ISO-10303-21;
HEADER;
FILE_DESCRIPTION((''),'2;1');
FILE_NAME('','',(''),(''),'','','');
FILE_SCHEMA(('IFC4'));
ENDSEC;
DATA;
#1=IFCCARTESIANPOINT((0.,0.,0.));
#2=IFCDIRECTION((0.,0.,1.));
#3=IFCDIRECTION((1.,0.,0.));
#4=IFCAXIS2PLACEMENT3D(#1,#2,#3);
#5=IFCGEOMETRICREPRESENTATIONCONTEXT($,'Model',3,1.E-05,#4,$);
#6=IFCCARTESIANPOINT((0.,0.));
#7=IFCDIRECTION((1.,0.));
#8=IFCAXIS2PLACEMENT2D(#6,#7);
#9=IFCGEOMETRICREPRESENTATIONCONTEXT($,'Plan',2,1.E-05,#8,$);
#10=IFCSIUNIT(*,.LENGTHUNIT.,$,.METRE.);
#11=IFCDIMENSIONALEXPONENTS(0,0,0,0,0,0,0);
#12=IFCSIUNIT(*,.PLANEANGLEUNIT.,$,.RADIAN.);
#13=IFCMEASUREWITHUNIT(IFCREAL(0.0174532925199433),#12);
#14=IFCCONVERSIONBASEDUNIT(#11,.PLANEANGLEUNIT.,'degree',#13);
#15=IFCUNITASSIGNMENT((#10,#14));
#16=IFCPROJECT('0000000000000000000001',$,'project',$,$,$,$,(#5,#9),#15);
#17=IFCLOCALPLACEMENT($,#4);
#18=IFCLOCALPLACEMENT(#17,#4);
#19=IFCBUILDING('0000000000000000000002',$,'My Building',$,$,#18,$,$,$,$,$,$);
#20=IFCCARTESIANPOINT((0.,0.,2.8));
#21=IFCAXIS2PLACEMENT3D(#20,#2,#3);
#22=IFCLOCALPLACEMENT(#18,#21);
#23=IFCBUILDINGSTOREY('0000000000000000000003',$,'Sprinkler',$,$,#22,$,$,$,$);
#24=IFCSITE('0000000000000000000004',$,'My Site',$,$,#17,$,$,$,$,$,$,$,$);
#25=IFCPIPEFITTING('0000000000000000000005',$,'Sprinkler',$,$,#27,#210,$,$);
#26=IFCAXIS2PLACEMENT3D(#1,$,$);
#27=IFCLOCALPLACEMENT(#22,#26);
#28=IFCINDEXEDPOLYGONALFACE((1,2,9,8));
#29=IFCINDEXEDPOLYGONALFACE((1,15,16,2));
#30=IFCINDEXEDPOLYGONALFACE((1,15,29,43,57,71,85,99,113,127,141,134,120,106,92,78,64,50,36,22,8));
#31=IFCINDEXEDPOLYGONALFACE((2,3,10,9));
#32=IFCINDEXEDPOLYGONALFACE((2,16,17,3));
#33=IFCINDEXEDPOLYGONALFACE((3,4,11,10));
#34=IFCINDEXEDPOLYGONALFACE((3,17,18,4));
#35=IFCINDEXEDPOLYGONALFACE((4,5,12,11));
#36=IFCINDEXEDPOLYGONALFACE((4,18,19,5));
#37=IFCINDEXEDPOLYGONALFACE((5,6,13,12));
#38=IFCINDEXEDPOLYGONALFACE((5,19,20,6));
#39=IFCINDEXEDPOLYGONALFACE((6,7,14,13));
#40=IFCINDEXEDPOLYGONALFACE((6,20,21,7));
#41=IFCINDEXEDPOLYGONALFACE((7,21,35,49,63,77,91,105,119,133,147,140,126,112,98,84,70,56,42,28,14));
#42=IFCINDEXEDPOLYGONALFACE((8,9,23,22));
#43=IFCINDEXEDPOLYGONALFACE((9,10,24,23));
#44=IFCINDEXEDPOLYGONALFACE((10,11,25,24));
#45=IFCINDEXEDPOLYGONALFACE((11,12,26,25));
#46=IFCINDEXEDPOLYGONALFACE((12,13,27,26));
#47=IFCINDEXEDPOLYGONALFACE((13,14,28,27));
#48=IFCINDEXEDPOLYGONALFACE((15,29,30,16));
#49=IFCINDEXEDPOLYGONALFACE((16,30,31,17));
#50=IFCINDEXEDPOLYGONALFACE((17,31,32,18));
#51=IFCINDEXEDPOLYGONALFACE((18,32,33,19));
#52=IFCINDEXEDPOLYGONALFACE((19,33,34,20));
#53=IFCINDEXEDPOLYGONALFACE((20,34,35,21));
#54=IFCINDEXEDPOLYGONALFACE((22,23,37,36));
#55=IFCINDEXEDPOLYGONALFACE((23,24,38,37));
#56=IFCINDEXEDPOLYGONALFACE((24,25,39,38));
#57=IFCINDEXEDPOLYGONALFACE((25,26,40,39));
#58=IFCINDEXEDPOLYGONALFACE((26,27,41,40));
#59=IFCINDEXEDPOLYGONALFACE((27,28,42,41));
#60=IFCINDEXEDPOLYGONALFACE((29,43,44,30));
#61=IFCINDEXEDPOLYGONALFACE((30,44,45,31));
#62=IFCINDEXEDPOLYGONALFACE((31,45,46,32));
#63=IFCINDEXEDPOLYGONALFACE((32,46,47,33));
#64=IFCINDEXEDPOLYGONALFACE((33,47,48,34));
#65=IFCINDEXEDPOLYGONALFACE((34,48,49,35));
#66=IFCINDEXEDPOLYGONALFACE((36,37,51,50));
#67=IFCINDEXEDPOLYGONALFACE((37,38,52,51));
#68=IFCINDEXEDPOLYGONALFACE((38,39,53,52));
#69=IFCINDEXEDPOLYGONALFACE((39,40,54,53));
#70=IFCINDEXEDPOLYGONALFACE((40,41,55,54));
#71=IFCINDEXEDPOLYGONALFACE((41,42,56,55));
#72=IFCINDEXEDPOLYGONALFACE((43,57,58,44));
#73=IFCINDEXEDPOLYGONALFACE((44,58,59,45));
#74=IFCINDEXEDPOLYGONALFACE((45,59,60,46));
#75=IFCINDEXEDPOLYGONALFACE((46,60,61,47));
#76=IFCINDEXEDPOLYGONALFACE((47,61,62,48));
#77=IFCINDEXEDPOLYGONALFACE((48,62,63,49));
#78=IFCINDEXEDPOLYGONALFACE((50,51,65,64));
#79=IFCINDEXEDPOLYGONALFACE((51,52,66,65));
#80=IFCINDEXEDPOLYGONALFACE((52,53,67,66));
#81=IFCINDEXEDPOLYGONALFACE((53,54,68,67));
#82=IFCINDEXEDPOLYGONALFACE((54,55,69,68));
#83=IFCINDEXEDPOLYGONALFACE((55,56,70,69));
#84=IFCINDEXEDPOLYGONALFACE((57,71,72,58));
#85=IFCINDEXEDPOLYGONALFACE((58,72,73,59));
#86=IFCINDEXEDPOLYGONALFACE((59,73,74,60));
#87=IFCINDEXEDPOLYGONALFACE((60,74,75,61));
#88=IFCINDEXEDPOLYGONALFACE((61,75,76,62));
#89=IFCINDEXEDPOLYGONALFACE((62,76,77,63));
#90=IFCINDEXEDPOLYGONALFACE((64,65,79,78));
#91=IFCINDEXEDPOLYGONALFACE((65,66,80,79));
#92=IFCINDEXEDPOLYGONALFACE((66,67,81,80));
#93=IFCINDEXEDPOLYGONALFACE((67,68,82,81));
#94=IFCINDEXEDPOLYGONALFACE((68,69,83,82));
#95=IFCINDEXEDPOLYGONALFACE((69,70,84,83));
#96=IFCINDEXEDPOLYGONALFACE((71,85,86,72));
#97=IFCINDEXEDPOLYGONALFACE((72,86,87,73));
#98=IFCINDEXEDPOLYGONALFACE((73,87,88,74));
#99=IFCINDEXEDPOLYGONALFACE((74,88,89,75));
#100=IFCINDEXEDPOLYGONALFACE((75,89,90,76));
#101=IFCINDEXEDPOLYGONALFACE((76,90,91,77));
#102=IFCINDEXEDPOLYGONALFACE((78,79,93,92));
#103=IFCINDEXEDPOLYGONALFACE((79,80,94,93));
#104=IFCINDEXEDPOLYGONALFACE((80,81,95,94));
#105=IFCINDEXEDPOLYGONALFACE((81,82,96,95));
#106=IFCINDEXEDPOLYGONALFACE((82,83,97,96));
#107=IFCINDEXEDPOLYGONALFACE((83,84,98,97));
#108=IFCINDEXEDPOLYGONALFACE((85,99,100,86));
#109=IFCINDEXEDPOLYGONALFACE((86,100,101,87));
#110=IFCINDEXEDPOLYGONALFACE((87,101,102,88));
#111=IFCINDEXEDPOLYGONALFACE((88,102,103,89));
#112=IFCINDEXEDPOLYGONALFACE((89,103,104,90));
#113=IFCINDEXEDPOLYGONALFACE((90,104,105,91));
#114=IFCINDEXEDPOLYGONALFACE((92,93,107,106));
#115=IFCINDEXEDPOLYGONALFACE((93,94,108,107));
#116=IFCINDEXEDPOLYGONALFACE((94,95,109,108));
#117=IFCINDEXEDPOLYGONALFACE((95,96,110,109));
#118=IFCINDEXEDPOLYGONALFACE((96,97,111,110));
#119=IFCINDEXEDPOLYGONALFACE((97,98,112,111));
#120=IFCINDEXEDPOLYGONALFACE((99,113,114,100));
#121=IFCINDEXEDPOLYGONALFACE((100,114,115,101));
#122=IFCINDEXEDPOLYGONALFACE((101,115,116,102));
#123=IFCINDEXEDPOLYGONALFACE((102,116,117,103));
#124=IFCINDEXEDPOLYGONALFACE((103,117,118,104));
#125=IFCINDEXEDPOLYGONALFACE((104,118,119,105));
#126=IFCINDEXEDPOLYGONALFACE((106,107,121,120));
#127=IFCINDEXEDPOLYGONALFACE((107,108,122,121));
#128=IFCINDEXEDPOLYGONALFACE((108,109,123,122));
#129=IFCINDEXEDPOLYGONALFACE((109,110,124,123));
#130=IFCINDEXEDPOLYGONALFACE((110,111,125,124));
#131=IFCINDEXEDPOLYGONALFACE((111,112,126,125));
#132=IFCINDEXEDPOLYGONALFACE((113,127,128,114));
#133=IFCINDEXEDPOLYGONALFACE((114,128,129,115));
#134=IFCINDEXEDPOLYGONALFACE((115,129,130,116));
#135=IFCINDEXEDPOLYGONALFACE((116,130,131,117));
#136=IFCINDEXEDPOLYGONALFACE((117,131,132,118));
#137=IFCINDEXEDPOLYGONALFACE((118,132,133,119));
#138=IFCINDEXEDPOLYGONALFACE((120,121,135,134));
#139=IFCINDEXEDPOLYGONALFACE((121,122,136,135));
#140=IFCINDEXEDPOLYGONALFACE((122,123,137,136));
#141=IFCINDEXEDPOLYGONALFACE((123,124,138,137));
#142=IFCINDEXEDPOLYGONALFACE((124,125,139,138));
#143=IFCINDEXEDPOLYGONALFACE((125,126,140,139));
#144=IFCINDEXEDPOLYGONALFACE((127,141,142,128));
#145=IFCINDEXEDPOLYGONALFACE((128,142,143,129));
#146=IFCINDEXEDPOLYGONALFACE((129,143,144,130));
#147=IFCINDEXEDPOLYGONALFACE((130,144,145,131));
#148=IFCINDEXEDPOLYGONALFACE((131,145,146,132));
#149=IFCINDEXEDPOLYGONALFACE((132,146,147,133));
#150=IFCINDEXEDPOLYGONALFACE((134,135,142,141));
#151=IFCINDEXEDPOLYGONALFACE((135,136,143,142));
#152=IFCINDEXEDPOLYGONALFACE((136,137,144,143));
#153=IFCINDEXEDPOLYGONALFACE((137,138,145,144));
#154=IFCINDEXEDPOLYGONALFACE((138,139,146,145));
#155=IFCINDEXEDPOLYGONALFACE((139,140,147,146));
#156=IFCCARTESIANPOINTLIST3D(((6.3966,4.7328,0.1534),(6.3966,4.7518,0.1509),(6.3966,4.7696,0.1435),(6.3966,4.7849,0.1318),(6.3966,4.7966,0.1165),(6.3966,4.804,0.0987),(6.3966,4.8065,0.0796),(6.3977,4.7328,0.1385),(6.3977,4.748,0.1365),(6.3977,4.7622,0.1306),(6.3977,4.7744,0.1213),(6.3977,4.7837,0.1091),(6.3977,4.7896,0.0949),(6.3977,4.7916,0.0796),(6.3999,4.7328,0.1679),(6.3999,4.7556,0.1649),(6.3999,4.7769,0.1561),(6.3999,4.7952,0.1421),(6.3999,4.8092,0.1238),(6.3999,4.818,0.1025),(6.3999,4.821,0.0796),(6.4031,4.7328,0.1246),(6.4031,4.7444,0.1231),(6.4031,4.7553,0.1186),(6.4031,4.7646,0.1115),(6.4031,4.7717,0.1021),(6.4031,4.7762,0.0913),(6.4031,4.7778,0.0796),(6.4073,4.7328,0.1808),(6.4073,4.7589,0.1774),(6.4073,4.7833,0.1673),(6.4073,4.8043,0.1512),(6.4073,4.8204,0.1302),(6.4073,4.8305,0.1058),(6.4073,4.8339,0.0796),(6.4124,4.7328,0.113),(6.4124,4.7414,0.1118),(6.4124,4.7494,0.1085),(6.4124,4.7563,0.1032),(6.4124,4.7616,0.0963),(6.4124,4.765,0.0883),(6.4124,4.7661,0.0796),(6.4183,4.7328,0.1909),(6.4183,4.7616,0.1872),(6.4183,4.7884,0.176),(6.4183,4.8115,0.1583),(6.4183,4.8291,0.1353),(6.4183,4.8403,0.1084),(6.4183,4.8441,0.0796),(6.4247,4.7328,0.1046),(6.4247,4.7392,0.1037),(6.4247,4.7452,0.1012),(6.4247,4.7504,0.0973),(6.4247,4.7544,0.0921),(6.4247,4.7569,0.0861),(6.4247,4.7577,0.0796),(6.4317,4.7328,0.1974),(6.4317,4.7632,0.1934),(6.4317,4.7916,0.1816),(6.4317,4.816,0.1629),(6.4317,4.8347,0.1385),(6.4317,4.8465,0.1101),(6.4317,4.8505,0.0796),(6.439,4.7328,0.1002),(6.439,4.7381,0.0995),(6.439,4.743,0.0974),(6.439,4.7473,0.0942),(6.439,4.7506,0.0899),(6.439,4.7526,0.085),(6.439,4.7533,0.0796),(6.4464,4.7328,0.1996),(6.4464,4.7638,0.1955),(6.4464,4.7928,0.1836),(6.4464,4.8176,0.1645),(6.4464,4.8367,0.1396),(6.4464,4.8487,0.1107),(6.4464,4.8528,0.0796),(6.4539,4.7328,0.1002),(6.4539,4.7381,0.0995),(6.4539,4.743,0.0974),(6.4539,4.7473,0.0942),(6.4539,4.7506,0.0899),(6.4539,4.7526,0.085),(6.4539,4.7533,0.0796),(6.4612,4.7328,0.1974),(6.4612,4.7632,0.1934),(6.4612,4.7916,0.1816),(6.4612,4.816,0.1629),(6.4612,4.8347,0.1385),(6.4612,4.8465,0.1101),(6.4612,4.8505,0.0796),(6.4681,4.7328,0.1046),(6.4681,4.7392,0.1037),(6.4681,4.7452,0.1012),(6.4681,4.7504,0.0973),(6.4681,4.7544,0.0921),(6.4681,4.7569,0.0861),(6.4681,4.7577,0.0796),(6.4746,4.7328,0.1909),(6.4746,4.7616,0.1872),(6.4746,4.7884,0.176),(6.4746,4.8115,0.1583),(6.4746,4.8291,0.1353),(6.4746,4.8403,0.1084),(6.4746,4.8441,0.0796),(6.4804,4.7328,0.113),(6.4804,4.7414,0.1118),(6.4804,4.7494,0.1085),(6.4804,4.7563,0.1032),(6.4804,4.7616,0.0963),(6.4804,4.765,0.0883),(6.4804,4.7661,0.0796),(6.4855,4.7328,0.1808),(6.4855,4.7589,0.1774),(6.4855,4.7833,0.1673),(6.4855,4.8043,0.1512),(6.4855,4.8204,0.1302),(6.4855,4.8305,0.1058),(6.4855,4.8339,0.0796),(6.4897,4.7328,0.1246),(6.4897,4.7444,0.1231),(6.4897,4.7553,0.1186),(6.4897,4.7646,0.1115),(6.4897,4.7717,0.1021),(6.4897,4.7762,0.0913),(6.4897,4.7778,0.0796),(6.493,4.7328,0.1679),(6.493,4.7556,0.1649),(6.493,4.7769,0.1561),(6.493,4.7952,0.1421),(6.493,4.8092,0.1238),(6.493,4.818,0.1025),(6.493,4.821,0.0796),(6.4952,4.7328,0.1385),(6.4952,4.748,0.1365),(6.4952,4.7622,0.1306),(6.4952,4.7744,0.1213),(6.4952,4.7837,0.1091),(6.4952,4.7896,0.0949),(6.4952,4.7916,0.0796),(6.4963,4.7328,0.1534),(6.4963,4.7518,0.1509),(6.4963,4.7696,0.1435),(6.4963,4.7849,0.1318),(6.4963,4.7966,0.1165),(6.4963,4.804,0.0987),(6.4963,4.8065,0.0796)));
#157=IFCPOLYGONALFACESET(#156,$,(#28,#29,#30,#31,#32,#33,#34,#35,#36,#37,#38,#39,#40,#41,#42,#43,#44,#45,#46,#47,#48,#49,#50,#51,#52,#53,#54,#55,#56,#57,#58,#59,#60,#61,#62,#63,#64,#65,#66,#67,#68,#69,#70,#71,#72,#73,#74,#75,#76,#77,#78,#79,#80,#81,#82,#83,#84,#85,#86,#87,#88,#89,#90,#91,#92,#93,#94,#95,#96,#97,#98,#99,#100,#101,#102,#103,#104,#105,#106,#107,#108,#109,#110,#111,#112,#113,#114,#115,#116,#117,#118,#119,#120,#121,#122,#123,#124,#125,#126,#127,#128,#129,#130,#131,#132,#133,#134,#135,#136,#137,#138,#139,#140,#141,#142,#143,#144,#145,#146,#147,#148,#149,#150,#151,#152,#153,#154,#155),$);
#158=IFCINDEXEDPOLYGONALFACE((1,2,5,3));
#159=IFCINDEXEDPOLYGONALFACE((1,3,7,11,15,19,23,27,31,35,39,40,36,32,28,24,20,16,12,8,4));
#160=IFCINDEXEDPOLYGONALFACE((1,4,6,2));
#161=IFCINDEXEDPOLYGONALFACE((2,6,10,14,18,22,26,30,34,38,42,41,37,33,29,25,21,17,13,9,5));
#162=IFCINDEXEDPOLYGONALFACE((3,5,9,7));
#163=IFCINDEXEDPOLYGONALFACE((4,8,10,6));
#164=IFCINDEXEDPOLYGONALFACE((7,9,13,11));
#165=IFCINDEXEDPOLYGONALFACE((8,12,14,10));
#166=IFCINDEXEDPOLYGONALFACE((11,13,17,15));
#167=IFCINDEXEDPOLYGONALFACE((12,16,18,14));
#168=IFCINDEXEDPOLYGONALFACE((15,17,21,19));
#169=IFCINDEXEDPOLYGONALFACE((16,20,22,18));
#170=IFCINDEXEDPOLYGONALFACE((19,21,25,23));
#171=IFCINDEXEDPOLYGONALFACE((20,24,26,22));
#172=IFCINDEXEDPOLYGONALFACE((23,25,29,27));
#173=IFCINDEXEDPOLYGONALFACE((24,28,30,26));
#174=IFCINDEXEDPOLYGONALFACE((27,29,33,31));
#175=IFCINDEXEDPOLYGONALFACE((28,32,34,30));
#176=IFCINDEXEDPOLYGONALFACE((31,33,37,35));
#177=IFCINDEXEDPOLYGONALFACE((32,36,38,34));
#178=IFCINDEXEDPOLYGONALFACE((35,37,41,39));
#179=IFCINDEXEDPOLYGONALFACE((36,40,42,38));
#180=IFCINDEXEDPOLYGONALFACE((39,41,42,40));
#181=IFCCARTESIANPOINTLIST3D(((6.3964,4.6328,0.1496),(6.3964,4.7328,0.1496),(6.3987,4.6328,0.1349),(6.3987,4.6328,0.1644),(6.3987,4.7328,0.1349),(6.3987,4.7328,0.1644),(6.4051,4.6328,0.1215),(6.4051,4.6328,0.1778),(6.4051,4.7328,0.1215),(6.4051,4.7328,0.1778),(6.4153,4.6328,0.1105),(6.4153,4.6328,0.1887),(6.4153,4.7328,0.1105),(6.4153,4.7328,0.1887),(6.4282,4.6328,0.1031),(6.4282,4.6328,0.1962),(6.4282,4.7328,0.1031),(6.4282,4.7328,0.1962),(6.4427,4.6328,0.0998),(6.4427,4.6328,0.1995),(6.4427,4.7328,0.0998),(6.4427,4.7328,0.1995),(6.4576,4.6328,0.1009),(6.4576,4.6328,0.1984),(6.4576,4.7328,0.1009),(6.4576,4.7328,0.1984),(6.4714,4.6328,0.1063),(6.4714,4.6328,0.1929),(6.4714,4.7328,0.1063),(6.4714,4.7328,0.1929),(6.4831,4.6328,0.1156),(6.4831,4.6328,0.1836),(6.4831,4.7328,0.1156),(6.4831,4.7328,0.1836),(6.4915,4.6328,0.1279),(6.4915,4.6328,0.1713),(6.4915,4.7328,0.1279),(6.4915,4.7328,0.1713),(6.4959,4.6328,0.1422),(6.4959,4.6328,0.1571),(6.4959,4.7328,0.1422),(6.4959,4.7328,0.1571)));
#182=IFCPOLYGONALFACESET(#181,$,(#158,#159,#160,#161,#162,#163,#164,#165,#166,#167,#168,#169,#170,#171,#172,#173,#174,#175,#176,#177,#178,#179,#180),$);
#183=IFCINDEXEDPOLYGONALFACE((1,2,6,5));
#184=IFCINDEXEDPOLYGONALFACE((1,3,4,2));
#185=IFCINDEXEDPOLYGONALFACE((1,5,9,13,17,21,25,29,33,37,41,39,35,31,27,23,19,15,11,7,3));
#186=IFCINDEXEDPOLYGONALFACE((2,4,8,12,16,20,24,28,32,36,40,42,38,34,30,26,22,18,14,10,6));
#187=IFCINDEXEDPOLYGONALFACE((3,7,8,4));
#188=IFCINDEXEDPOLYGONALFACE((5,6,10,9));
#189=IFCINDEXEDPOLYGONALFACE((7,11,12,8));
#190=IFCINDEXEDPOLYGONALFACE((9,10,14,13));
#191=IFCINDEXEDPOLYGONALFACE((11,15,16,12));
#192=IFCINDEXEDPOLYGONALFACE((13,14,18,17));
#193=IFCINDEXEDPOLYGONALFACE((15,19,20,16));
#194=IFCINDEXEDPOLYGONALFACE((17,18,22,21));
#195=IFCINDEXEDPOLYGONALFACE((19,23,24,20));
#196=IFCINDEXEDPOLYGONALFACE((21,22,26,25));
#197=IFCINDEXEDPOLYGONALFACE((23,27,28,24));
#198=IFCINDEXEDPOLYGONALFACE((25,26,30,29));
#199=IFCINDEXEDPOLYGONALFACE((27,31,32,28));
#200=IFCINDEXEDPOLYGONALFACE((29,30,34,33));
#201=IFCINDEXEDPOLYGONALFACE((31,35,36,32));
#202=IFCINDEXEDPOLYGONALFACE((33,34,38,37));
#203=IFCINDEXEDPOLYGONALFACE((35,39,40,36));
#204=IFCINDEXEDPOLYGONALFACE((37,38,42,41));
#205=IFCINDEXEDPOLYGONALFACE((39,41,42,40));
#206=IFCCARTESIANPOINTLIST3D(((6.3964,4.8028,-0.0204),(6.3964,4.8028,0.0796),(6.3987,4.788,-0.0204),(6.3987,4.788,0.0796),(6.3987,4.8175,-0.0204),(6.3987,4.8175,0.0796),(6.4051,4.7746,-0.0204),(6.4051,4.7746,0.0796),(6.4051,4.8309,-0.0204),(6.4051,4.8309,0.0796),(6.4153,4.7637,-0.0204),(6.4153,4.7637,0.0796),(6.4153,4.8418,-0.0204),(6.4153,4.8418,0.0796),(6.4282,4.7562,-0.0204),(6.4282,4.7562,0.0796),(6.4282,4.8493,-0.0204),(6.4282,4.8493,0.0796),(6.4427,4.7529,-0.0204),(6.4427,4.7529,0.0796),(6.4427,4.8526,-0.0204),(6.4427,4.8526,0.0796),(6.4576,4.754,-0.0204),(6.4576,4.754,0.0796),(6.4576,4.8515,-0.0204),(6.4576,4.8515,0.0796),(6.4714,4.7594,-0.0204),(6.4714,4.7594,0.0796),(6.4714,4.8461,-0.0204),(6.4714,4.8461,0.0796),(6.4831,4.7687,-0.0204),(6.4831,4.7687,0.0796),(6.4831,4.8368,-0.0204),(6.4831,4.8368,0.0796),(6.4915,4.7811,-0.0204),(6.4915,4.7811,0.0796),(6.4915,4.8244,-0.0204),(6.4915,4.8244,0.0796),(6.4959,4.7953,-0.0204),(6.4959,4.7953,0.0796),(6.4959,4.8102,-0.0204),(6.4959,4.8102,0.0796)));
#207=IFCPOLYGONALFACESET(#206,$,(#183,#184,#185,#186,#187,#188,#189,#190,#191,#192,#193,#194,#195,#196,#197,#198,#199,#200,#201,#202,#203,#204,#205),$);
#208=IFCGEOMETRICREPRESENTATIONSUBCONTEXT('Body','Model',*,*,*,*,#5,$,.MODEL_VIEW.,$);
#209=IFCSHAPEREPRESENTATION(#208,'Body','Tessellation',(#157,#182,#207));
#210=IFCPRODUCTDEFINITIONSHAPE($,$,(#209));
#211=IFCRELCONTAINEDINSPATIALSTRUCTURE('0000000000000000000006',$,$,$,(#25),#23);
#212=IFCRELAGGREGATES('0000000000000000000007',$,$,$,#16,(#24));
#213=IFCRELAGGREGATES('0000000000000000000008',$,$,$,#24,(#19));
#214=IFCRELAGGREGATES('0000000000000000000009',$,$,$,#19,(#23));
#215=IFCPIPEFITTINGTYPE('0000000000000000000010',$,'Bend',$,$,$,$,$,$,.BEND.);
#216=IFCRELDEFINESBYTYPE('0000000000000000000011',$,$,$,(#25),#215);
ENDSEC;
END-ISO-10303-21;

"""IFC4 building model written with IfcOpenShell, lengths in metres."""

from ifc_helpers import new_model, entity, si_unit, converted_unit, frame, origin_with_axes, origin_2d_with_axis, place, context, subcontext, project, spatial, circle, extrude, source, transform, mapped, type_object, type_shapes, element, save


model = new_model("IFC4")

# Units and contexts
model_context = context("Model", 3, precision=1e-05, world=origin_with_axes())
plan_context = context("Plan", 2, precision=1e-05, world=origin_2d_with_axis())
body_context = subcontext(model_context, "Body", "Model", "MODEL_VIEW")
ifc_project = project(units=[si_unit("LENGTHUNIT", "METRE"), converted_unit("PLANEANGLEUNIT", "degree", entity("IfcReal", 0.0174532925199433), si_unit("PLANEANGLEUNIT", "RADIAN"), dimensions=[0, 0, 0, 0, 0, 0, 0])], contexts=[model_context, plan_context])

# Site, building, storey
site_placement = place(None, origin_with_axes())
site = spatial("IfcSite", under=ifc_project, at=site_placement, Name="My Site")
building_placement = place(site_placement, origin_with_axes())
building = spatial("IfcBuilding", under=site, at=building_placement, Name="My Building")
storey_placement = place(building_placement, frame((0.0, 0.0, 2.8), z_axis=(0.0, 0.0, 1.0), x_axis=(1.0, 0.0, 0.0)))
storey = spatial("IfcBuildingStorey", under=building, at=storey_placement, Name="Sprinkler")

# Pipe fitting
pipe_fitting_type_1 = type_object("IfcPipeFittingType", Name="Bend", PredefinedType="BEND")
shared_shape_1 = source(origin_with_axes(), body_context, "Body", "SolidModel", [
    entity("IfcSweptDiskSolid", entity("IfcIndexedPolyCurve", entity("IfcCartesianPointList3D", [[0.0, 0.0, 0.1], [0.0, -0.0205, 0.1495], [0.0, -0.07, 0.17]]), [entity("IfcArcIndex", [1, 2, 3])]), 0.05),
    extrude(circle(Radius=0.05), origin_with_axes(), (0.0, 0.0, 1.0), 0.1),
    extrude(circle(Radius=0.05), frame((0.0, -0.07, 0.17), z_axis=(0.0, -1.0, 0.0), x_axis=(1.0, 0.0, 0.0)), (0.0, 0.0, 1.0), 0.1),
])
type_shapes(pipe_fitting_type_1, [shared_shape_1])
for number, where, z_axis, x_axis, name in (
    (1, (6.4464, 4.6328, 0.1496), (-0.000001, 1.0, 0.0), (-1.0, -0.000001, 0.0), "Sprinkler"),
):
    element("IfcPipeFitting", number, at=place(storey_placement, frame(where, z_axis=z_axis, x_axis=x_axis)), inside=storey, type_object=pipe_fitting_type_1, Name=name, context=body_context, shape_type="MappedRepresentation", body=[
        mapped(shared_shape_1, transform((0.0, 0.0, 0.0), x_axis=(1.0, 0.0, 0.0), y_axis=(0.0, 1.0, 0.0), z_axis=(0.0, 0.0, 1.0), scale=1.0)),
    ])

save(model, "model.ifc")
